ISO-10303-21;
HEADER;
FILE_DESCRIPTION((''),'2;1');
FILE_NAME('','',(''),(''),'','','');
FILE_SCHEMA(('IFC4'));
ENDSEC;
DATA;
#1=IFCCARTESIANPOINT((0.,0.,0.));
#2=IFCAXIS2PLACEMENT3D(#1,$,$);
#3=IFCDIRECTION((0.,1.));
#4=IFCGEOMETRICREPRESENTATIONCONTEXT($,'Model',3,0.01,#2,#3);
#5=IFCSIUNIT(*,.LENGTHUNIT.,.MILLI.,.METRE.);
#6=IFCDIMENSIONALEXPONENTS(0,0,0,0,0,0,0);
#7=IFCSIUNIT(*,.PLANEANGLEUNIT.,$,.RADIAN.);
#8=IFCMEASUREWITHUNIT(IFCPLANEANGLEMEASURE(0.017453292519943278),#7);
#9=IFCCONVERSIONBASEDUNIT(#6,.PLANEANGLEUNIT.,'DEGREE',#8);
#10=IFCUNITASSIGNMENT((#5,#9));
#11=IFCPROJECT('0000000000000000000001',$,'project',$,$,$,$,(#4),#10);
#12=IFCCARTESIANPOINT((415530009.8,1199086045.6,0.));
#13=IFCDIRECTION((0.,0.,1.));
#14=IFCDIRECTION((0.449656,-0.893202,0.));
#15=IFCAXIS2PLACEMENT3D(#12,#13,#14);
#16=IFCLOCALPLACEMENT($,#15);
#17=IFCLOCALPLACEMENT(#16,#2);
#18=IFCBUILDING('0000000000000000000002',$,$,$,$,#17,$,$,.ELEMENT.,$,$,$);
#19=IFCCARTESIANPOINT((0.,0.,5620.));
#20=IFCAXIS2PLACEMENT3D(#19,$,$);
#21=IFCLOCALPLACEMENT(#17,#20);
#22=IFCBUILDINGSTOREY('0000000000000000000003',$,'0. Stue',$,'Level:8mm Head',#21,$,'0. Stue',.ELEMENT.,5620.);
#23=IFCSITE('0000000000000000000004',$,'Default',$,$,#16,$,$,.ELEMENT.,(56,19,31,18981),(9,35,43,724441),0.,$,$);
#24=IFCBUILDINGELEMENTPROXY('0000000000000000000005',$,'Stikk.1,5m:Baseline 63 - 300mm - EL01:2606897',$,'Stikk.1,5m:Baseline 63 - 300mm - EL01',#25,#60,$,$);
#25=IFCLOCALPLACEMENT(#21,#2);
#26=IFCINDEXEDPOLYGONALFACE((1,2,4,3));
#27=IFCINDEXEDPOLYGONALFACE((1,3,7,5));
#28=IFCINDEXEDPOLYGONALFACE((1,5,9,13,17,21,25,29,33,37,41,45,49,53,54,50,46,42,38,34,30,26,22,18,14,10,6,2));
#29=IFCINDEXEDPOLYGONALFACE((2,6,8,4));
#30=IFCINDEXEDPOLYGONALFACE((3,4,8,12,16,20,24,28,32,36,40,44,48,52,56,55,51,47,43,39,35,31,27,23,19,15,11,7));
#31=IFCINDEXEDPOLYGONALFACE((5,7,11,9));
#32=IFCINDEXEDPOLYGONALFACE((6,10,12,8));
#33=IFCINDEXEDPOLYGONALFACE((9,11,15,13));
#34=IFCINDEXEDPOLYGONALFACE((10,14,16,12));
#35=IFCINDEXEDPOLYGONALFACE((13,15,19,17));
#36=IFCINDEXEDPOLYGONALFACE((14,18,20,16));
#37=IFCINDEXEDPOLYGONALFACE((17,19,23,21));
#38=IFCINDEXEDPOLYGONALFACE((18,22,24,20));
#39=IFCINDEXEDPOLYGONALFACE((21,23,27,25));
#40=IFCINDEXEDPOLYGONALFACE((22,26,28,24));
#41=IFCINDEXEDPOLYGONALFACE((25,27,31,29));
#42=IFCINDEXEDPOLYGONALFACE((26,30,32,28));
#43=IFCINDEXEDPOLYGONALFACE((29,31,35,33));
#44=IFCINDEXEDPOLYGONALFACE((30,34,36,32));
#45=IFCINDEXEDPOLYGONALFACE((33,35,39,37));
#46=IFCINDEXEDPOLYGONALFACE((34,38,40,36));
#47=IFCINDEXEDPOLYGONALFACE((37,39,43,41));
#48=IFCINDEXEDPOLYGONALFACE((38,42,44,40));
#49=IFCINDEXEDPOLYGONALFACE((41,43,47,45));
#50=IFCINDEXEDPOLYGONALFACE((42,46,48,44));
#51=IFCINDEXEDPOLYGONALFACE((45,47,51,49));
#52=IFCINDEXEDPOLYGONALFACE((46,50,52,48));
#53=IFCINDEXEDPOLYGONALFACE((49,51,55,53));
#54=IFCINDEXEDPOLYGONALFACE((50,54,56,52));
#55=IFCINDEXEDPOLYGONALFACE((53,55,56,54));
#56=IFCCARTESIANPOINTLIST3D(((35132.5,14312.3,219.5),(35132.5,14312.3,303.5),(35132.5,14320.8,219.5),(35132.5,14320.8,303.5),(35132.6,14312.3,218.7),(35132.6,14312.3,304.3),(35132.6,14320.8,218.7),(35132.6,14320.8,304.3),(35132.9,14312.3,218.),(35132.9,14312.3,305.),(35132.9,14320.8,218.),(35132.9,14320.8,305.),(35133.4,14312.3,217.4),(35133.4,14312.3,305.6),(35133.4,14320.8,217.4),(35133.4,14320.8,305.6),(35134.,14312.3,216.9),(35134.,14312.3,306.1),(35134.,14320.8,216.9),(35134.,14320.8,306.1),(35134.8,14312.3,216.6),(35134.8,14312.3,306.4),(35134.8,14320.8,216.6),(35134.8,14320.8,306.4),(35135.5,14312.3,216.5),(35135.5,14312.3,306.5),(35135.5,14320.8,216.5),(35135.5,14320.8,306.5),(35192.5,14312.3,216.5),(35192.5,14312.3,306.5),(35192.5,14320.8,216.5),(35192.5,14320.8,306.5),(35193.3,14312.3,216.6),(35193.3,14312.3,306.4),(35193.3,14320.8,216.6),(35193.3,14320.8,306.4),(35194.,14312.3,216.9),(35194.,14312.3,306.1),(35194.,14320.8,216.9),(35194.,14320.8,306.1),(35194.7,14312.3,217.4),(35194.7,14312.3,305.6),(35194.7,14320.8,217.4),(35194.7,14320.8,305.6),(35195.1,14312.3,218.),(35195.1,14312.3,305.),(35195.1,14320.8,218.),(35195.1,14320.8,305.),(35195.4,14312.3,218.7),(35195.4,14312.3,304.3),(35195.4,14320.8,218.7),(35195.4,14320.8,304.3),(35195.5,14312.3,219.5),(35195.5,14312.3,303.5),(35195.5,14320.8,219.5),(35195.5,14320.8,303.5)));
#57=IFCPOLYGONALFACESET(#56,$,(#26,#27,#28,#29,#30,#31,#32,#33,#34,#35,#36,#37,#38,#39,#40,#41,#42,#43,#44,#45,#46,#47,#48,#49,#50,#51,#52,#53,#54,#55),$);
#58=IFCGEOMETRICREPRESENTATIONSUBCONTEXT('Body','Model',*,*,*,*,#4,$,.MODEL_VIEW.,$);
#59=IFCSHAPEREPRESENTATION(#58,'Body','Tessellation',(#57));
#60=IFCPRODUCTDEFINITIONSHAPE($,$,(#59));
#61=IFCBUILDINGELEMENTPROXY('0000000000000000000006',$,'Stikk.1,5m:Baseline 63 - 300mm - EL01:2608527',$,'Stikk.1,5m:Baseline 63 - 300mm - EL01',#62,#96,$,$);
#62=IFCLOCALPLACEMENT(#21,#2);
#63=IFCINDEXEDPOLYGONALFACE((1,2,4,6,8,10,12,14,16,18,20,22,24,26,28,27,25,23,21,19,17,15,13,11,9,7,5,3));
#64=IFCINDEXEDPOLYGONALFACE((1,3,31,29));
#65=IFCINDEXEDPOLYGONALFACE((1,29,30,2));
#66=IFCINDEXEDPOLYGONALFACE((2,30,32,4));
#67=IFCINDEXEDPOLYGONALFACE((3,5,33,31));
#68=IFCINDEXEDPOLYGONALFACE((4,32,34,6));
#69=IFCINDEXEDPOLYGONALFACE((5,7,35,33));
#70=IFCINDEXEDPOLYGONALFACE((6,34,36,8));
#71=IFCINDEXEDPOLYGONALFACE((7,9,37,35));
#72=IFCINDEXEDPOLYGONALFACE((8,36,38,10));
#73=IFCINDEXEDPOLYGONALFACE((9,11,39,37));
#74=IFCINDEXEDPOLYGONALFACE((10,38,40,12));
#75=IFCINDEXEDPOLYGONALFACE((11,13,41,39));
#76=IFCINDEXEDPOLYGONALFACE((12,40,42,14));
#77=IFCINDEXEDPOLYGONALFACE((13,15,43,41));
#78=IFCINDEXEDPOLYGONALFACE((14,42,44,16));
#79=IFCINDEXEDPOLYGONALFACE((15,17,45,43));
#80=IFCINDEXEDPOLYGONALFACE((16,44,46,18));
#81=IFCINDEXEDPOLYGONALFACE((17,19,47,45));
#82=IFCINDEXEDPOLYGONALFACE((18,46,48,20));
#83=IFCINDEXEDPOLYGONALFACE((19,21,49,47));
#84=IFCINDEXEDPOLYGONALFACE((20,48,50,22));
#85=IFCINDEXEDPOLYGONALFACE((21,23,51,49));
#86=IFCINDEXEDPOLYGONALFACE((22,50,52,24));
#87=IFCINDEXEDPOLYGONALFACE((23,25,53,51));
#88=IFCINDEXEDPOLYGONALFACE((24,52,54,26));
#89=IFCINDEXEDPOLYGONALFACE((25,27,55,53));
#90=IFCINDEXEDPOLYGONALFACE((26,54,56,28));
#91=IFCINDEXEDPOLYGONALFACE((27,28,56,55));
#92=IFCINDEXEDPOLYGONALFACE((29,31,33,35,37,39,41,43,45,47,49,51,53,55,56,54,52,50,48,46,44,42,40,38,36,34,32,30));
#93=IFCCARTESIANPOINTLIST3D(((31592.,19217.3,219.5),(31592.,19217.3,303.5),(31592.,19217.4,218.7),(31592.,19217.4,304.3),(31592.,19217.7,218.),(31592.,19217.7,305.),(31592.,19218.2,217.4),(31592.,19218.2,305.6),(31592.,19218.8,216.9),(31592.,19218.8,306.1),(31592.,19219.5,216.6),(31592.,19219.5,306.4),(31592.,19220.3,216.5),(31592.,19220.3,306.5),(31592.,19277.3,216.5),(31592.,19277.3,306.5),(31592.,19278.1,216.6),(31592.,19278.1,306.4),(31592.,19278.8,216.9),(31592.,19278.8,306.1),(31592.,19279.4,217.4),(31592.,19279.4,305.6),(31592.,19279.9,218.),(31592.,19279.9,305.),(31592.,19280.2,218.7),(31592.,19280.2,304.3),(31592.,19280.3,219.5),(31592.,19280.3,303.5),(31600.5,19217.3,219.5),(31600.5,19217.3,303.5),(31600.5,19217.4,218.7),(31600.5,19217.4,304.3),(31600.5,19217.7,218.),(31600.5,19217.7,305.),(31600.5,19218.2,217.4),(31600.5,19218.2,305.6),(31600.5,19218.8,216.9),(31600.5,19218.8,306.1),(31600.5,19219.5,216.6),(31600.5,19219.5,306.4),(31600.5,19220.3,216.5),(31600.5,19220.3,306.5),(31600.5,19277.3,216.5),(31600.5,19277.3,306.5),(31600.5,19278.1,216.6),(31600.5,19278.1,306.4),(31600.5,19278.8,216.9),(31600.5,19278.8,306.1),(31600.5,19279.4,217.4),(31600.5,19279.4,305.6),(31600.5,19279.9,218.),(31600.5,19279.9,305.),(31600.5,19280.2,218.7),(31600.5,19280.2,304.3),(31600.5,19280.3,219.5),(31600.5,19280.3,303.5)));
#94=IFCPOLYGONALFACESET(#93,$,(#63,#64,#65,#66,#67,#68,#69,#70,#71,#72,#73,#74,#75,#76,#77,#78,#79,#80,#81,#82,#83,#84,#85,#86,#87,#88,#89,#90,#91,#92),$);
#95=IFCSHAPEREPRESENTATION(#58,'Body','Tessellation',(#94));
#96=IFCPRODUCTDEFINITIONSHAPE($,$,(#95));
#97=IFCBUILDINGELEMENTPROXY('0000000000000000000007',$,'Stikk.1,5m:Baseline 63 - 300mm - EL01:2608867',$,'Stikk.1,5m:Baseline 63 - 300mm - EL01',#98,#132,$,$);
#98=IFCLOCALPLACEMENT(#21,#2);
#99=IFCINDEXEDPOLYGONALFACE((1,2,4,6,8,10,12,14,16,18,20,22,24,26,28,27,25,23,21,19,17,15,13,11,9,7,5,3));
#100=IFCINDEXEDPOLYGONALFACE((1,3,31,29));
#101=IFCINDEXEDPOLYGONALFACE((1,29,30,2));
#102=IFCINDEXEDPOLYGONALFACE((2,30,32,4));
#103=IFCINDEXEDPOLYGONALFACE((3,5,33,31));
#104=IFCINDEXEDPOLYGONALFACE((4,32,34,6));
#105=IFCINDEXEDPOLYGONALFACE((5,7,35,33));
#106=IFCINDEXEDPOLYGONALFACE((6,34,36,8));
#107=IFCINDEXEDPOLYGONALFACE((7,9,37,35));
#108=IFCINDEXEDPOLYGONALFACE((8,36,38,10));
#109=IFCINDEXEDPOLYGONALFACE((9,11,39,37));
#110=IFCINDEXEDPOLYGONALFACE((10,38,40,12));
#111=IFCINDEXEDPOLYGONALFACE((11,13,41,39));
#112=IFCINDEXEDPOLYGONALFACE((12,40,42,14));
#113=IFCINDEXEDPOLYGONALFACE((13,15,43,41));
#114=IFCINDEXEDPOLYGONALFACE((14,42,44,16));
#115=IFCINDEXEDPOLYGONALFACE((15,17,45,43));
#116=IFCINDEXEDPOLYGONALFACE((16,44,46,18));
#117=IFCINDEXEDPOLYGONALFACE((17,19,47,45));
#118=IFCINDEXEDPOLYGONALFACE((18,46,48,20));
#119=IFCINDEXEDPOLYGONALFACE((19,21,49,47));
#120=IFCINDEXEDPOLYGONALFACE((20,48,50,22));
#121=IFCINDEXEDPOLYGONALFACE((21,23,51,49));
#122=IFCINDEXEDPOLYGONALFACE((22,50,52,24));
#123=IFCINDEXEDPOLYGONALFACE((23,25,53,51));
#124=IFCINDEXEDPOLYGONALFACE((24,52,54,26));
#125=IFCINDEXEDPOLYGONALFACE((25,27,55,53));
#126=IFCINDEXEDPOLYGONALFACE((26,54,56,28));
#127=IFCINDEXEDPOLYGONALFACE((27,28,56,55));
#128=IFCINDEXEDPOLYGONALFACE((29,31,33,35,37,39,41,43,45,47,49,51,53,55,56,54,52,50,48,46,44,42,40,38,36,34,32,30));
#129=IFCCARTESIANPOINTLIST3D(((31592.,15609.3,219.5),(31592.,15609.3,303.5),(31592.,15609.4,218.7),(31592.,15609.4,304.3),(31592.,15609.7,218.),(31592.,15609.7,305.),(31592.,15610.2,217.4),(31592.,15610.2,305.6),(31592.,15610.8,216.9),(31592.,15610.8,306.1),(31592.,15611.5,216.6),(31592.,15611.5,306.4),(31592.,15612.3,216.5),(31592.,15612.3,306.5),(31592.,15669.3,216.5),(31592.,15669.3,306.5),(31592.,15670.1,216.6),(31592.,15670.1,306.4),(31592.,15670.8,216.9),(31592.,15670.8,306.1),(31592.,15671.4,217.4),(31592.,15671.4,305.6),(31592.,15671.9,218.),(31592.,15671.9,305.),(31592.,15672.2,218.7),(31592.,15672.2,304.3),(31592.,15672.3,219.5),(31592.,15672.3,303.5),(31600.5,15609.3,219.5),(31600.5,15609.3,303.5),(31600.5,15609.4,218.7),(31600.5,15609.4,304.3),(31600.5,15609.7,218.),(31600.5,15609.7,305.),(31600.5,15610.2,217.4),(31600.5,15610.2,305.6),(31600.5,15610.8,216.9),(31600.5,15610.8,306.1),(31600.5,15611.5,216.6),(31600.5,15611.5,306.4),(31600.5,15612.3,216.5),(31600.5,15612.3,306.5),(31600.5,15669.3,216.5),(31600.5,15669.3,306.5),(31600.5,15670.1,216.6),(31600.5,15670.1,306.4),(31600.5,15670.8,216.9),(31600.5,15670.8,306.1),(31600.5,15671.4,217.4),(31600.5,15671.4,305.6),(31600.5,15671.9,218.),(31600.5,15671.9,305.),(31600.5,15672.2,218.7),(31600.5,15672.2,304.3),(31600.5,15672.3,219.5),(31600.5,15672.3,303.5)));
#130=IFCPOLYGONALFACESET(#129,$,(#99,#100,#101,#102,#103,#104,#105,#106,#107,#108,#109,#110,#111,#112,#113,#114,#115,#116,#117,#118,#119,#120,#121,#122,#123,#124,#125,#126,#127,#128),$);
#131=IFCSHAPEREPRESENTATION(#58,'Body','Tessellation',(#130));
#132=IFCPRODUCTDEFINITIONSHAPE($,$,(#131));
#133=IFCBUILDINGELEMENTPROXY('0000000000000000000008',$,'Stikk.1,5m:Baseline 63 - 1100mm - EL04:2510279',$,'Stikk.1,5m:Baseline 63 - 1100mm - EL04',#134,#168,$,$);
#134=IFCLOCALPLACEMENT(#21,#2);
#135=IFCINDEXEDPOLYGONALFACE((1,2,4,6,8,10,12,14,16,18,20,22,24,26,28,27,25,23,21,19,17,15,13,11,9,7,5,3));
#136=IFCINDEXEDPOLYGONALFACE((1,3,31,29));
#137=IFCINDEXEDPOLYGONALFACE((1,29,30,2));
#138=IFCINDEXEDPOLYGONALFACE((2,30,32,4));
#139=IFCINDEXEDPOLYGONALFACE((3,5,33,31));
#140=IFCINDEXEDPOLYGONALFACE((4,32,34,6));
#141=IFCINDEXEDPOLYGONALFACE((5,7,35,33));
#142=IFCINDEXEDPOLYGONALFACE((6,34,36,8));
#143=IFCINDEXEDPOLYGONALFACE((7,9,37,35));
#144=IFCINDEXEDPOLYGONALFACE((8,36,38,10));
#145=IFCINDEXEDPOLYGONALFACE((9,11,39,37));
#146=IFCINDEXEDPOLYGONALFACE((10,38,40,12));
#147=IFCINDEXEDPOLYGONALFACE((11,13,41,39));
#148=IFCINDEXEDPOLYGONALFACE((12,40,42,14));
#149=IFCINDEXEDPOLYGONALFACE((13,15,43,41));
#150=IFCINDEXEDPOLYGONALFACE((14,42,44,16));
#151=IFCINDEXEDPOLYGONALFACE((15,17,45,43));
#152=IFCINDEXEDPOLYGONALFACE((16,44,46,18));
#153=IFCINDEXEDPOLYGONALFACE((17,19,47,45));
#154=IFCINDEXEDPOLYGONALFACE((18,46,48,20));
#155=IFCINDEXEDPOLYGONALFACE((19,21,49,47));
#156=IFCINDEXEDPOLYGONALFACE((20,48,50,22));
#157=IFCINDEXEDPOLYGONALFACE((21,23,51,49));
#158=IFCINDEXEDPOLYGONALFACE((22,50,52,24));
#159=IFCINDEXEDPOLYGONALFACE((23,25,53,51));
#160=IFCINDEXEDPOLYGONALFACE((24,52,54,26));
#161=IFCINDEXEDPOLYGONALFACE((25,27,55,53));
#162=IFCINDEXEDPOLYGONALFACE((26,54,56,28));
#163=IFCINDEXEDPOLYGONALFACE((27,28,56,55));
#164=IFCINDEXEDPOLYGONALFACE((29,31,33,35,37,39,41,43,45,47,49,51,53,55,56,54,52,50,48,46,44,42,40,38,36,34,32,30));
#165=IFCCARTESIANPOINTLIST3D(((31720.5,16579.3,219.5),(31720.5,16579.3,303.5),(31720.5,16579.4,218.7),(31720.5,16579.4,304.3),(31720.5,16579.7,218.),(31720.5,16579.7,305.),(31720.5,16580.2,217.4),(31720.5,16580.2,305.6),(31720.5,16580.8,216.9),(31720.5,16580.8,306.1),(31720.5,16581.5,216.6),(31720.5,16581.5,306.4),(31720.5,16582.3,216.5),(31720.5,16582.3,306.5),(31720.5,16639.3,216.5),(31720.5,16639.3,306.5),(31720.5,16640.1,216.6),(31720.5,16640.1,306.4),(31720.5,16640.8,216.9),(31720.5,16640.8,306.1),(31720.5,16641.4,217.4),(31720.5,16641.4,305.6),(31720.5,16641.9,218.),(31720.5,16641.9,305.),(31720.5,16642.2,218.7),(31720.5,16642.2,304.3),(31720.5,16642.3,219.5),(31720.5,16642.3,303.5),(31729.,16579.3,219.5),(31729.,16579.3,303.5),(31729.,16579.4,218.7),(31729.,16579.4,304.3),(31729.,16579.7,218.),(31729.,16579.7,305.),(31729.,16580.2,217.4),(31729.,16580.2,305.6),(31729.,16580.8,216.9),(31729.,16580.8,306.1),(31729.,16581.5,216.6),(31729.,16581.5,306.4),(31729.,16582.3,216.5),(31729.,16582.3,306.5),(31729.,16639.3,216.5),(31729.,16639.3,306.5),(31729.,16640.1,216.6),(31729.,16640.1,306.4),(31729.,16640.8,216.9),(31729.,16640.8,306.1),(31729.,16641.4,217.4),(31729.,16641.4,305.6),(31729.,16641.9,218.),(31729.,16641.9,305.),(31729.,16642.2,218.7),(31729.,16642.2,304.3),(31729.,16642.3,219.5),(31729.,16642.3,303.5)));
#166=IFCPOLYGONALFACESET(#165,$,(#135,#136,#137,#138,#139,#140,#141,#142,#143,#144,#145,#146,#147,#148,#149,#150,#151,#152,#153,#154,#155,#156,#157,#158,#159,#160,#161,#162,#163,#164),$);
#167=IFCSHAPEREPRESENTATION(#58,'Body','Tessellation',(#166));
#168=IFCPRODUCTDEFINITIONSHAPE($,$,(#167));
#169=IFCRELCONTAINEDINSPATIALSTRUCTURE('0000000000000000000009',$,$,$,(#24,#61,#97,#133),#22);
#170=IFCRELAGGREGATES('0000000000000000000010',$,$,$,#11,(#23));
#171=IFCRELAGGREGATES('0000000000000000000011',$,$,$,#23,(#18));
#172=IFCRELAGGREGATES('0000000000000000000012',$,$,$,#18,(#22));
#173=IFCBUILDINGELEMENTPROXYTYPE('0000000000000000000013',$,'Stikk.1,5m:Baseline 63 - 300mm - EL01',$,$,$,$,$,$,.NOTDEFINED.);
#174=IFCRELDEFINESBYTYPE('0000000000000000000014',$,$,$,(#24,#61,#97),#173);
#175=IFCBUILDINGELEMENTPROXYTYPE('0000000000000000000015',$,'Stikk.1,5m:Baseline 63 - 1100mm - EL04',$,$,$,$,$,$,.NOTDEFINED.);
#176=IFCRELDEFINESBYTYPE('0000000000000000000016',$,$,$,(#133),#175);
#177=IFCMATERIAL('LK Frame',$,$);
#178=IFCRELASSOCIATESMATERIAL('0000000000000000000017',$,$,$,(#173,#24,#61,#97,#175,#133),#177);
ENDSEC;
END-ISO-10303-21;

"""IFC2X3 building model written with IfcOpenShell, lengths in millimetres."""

from ifc_helpers import new_model, entity, si_unit, converted_unit, direction, frame, frame_2d, origin, place, context, subcontext, project, spatial, polyline, circle_curve, parameter, trimmed, segment, composite_curve, outline, extrude, source, transform, mapped, material, type_object, type_shapes, element, save


model = new_model("IFC2X3")

# Units and contexts
model_context = context("Model", 3, precision=0.01, world=origin(), true_north=direction((0.0, 1.0)))
body_context = subcontext(model_context, "Body", "Model", "MODEL_VIEW")
ifc_project = project(units=[si_unit("LENGTHUNIT", "METRE", prefix="MILLI"), converted_unit("PLANEANGLEUNIT", "DEGREE", entity("IfcPlaneAngleMeasure", 0.017453292519943278), si_unit("PLANEANGLEUNIT", "RADIAN"), dimensions=[0, 0, 0, 0, 0, 0, 0])], contexts=[model_context])

# Site, building, storey
site_placement = place(None, frame((415530009.8, 1199086045.6, 0.0), z_axis=(0.0, 0.0, 1.0), x_axis=(0.449656, -0.893202, 0.0)))
site = spatial("IfcSite", under=ifc_project, at=site_placement, Name="Default", CompositionType="ELEMENT", RefLatitude=(56, 19, 31, 18981), RefLongitude=(9, 35, 43, 724441), RefElevation=0.0)
building_placement = place(site_placement, origin())
building = spatial("IfcBuilding", under=site, at=building_placement, CompositionType="ELEMENT")
storey_placement = place(building_placement, frame((0.0, 0.0, 5620.0)))
storey = spatial("IfcBuildingStorey", under=building, at=storey_placement, Name="0. Stue", ObjectType="Level:8mm Head", LongName="0. Stue", CompositionType="ELEMENT", Elevation=5620.0)

# Building element proxies
ifc_material_1 = material(Name="LK Frame")
building_element_proxy_type_1 = type_object("IfcBuildingElementProxyType", Name="Stikk.1,5m:Baseline 63 - 300mm - EL01", PredefinedType="NOTDEFINED", material=ifc_material_1)
shared_shape_1 = source(origin(), body_context, "Body", "SweptSolid", [
    extrude(outline(composite_curve([segment(polyline([(-42.0, -31.5), (42.0, -31.5)]), True, "CONTINUOUS"), segment(trimmed(circle_curve(frame_2d((42.0, -28.5), x_axis=(-1.0, 0.0)), 3.0), [parameter(90.0)], [parameter(180.0)], True, "PARAMETER"), True, "CONTINUOUS"), segment(polyline([(45.0, -28.5), (45.0, 28.5)]), True, "CONTINUOUS"), segment(trimmed(circle_curve(frame_2d((42.0, 28.5), x_axis=(-1.0, 0.0)), 3.0), [parameter(180.0)], [parameter(270.0)], True, "PARAMETER"), True, "CONTINUOUS"), segment(polyline([(42.0, 31.5), (-42.0, 31.5)]), True, "CONTINUOUS"), segment(trimmed(circle_curve(frame_2d((-42.0, 28.5), x_axis=(1.0, 0.0)), 3.0), [parameter(90.0)], [parameter(180.0)], True, "PARAMETER"), True, "CONTINUOUS"), segment(polyline([(-45.0, 28.5), (-45.0, -28.5)]), True, "CONTINUOUS"), segment(trimmed(circle_curve(frame_2d((-42.0, -28.5), x_axis=(1.0, 0.0)), 3.0), [parameter(180.0)], [parameter(270.0)], True, "PARAMETER"), True, "CONTINUOUS")], self_intersect=False)), frame((0.0, -38.5, 0.0), z_axis=(0.0, 0.0, 1.0), x_axis=(0.0, 1.0, 0.0)), (0.0, 0.0, 1.0), 8.5),
])
type_shapes(building_element_proxy_type_1, [shared_shape_1])
for number, where, z_axis, x_axis, name in (
    (1, (35164.0, 14320.8, 300.0), (0.0, -1.0, 0.0), (1.0, 0.0, 0.0), "Stikk.1,5m:Baseline 63 - 300mm - EL01:2606897"),
    (2, (31600.5, 19248.8, 300.0), (-1.0, 0.0, 0.0), (0.0, -1.0, 0.0), "Stikk.1,5m:Baseline 63 - 300mm - EL01:2608527"),
    (3, (31600.5, 15640.8, 300.0), (-1.0, 0.0, 0.0), (0.0, -1.0, 0.0), "Stikk.1,5m:Baseline 63 - 300mm - EL01:2608867"),
):
    element("IfcBuildingElementProxy", number, at=place(storey_placement, frame(where, z_axis=z_axis, x_axis=x_axis)), inside=storey, type_object=building_element_proxy_type_1, material=ifc_material_1, Name=name, ObjectType="Stikk.1,5m:Baseline 63 - 300mm - EL01", context=body_context, shape_type="MappedRepresentation", body=[
        mapped(shared_shape_1, transform((0.0, 0.0, 0.0), scale=1.0)),
    ])
building_element_proxy_type_2 = type_object("IfcBuildingElementProxyType", Name="Stikk.1,5m:Baseline 63 - 1100mm - EL04", PredefinedType="NOTDEFINED", material=ifc_material_1)
shared_shape_2 = source(origin(), body_context, "Body", "SweptSolid", [
    extrude(outline(composite_curve([segment(polyline([(-42.0, -31.5), (42.0, -31.5)]), True, "CONTINUOUS"), segment(trimmed(circle_curve(frame_2d((42.0, -28.5), x_axis=(-1.0, 0.0)), 3.0), [parameter(90.0)], [parameter(180.0)], True, "PARAMETER"), True, "CONTINUOUS"), segment(polyline([(45.0, -28.5), (45.0, 28.5)]), True, "CONTINUOUS"), segment(trimmed(circle_curve(frame_2d((42.0, 28.5), x_axis=(-1.0, 0.0)), 3.0), [parameter(180.0)], [parameter(270.0)], True, "PARAMETER"), True, "CONTINUOUS"), segment(polyline([(42.0, 31.5), (-42.0, 31.5)]), True, "CONTINUOUS"), segment(trimmed(circle_curve(frame_2d((-42.0, 28.5), x_axis=(1.0, 0.0)), 3.0), [parameter(90.0)], [parameter(180.0)], True, "PARAMETER"), True, "CONTINUOUS"), segment(polyline([(-45.0, 28.5), (-45.0, -28.5)]), True, "CONTINUOUS"), segment(trimmed(circle_curve(frame_2d((-42.0, -28.5), x_axis=(1.0, 0.0)), 3.0), [parameter(180.0)], [parameter(270.0)], True, "PARAMETER"), True, "CONTINUOUS")], self_intersect=False)), frame((0.0, -38.5, 0.0), z_axis=(0.0, 0.0, 1.0), x_axis=(0.0, 1.0, 0.0)), (0.0, 0.0, 1.0), 8.5),
])
type_shapes(building_element_proxy_type_2, [shared_shape_2])
for number, where, z_axis, x_axis, name in (
    (4, (31720.5, 16610.8, 300.0), (1.0, 0.0, 0.0), (0.0, 1.0, 0.0), "Stikk.1,5m:Baseline 63 - 1100mm - EL04:2510279"),
):
    element("IfcBuildingElementProxy", number, at=place(storey_placement, frame(where, z_axis=z_axis, x_axis=x_axis)), inside=storey, type_object=building_element_proxy_type_2, material=ifc_material_1, Name=name, ObjectType="Stikk.1,5m:Baseline 63 - 1100mm - EL04", context=body_context, shape_type="MappedRepresentation", body=[
        mapped(shared_shape_2, transform((0.0, 0.0, 0.0), scale=1.0)),
    ])

save(model, "model.ifc")
